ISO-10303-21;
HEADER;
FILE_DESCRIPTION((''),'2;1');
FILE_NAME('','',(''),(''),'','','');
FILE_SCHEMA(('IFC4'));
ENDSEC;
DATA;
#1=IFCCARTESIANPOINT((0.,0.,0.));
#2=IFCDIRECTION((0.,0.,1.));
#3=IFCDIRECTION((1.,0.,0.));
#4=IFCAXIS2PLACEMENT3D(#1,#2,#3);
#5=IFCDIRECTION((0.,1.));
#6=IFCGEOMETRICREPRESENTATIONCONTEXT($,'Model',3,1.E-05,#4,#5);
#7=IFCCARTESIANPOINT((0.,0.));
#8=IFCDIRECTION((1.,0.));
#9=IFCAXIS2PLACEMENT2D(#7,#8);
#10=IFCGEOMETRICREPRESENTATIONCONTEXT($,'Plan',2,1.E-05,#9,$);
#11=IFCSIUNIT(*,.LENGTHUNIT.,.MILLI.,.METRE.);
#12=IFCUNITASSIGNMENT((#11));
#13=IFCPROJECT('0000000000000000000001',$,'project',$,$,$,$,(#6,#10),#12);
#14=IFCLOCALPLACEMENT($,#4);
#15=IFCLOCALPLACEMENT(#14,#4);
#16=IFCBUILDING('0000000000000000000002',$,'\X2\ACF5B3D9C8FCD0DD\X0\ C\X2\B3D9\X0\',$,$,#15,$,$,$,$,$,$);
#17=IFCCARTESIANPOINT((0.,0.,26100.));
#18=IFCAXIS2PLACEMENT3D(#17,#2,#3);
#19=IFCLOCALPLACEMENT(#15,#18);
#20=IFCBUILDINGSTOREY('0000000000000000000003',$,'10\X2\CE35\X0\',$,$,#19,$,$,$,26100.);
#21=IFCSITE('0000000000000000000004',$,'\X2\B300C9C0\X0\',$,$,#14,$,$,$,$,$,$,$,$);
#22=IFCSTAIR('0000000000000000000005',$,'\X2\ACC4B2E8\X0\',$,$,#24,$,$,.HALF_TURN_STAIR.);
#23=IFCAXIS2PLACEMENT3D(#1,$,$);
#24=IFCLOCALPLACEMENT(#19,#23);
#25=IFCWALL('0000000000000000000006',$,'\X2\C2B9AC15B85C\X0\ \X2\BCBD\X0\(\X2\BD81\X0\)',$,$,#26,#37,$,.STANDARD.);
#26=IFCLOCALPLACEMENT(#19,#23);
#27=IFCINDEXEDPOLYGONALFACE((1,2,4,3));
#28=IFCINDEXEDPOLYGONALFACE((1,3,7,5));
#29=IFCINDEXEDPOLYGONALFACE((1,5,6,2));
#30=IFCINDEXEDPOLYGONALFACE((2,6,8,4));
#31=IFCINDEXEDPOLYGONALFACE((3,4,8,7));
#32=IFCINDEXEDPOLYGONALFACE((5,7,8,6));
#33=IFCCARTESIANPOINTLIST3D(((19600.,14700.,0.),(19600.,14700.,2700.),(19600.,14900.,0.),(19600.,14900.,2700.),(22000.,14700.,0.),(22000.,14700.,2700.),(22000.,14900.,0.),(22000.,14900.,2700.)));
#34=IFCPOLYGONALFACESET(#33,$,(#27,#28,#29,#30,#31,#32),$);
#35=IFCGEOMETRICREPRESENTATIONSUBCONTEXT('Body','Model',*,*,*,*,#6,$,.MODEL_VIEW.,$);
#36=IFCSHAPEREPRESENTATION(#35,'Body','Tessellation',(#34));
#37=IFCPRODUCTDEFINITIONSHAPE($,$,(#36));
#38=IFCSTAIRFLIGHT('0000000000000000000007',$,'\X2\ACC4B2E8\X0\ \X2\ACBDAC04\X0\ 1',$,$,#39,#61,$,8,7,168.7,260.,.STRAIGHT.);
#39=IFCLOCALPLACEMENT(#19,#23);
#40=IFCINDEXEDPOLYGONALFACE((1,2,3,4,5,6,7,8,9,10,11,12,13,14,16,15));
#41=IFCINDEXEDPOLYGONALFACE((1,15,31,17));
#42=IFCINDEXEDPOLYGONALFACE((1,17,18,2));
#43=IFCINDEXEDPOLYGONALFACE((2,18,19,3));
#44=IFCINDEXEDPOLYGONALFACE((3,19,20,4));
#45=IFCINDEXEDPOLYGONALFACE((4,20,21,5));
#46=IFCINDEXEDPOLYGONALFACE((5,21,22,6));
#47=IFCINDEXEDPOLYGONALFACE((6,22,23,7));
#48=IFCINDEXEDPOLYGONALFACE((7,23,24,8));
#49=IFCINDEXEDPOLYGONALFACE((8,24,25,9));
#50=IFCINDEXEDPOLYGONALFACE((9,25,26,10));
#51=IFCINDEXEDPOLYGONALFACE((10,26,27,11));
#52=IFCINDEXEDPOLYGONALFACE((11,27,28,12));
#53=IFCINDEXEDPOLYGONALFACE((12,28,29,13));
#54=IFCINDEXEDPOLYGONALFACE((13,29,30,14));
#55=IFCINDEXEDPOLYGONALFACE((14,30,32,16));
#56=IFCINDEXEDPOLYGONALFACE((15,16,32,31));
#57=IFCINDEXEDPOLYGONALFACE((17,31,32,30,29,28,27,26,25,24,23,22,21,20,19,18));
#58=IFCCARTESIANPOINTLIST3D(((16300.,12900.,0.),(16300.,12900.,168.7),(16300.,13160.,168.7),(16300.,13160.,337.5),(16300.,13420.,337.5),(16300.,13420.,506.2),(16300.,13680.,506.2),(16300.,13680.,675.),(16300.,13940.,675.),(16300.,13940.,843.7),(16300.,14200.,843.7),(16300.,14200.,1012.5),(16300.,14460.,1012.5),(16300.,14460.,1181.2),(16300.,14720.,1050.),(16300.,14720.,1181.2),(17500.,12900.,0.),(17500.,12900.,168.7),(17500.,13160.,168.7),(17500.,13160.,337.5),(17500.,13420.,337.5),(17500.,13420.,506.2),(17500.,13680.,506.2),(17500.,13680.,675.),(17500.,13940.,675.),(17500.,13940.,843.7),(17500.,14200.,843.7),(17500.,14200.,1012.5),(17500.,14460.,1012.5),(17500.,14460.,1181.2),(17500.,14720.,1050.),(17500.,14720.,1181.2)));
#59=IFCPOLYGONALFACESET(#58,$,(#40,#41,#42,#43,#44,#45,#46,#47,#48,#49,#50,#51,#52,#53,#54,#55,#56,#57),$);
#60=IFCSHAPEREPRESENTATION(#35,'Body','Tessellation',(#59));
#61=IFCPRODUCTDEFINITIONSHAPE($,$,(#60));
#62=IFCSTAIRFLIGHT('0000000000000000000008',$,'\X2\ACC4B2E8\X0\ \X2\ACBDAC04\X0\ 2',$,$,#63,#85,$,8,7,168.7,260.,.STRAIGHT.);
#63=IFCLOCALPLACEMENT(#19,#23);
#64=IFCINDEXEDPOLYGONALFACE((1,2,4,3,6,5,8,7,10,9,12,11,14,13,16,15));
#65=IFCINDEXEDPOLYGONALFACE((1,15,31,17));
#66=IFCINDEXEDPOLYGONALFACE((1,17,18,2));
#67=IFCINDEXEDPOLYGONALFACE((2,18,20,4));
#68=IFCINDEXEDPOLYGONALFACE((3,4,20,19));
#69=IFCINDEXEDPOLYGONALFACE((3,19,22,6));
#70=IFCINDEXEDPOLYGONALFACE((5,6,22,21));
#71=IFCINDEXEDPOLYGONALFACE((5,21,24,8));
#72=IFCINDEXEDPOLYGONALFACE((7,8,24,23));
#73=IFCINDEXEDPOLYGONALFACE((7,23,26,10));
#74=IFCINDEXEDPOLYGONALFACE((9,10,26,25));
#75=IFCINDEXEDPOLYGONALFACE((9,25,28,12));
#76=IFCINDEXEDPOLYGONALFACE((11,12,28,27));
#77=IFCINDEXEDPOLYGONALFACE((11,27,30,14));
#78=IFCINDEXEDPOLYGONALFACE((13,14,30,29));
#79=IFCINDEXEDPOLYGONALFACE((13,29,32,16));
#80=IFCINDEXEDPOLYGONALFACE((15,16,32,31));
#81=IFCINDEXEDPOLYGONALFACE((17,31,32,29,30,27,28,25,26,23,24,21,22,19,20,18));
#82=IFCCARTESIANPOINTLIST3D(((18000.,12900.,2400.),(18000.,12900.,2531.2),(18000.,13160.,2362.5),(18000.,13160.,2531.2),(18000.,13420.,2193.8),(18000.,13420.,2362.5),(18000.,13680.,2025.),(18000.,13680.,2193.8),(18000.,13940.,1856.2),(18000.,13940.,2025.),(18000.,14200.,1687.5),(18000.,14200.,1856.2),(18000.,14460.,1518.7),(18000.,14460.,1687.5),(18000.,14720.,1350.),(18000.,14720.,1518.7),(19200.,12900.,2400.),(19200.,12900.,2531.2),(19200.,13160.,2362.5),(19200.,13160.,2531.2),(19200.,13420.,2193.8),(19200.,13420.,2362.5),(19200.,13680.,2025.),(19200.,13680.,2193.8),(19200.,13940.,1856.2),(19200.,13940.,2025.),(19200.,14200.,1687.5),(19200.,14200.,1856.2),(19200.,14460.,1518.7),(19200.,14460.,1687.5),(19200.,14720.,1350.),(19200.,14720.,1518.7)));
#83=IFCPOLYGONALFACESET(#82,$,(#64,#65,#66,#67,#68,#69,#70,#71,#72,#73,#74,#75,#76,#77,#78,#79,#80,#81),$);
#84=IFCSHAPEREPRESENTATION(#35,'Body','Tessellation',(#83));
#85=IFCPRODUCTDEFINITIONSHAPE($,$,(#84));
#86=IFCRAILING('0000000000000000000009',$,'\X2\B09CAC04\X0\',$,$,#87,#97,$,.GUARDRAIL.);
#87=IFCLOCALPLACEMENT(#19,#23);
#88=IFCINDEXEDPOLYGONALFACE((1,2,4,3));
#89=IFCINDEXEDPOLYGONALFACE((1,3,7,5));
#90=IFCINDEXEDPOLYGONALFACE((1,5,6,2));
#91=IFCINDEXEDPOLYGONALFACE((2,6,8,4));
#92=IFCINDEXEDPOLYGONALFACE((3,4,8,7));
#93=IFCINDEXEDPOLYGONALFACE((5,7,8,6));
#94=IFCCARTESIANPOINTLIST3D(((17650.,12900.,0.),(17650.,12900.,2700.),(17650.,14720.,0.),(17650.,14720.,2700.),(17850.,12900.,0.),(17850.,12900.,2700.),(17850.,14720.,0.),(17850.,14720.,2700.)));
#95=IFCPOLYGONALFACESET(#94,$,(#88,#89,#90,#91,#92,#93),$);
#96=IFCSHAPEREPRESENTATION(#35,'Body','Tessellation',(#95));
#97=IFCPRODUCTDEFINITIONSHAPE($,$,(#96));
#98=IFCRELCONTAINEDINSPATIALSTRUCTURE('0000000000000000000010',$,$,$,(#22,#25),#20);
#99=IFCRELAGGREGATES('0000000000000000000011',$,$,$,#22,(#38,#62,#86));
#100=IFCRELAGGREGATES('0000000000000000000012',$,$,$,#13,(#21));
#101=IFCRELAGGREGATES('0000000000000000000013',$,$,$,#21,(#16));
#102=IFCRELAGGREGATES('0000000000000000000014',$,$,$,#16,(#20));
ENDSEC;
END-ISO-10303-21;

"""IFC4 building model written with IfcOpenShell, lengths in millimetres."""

from ifc_helpers import new_model, si_unit, direction, frame, origin_with_axes, origin_2d_with_axis, place, context, subcontext, project, spatial, polyline, outline, extrude, element, aggregate, save


model = new_model("IFC4")

# Units and contexts
model_context = context("Model", 3, precision=1e-05, world=origin_with_axes(), true_north=direction((0.0, 1.0)))
plan_context = context("Plan", 2, precision=1e-05, world=origin_2d_with_axis())
body_context = subcontext(model_context, "Body", "Model", "MODEL_VIEW")
ifc_project = project(units=[si_unit("LENGTHUNIT", "METRE", prefix="MILLI")], contexts=[model_context, plan_context])

# Site, building, storey
site_placement = place(None, origin_with_axes())
site = spatial("IfcSite", under=ifc_project, at=site_placement, Name="대지")
building_placement = place(site_placement, origin_with_axes())
building = spatial("IfcBuilding", under=site, at=building_placement, Name="공동주택 C동")
storey_placement = place(building_placement, frame((0.0, 0.0, 26100.0), z_axis=(0.0, 0.0, 1.0), x_axis=(1.0, 0.0, 0.0)))
storey = spatial("IfcBuildingStorey", under=building, at=storey_placement, Name="10층", Elevation=26100.0)

# Stair
stair_placement = place(storey_placement, origin_with_axes())
stair = element("IfcStair", 1, at=stair_placement, inside=storey, Name="계단", PredefinedType="HALF_TURN_STAIR")

# Wall
wall_1_placement = place(storey_placement, origin_with_axes())
element("IfcWall", 2, at=wall_1_placement, inside=storey, Name="승강로 벽(북)", PredefinedType="STANDARD", context=body_context, shape_type="SweptSolid", body=[
    extrude(outline(polyline([(19600.0, 14900.0), (22000.0, 14900.0), (22000.0, 14700.0), (19600.0, 14700.0), (19600.0, 14900.0)])), origin_with_axes(), (0.0, 0.0, 1.0), 2700.0),
])

# Stair flights
stair_flight_1_placement = place(stair_placement, origin_with_axes())
stair_flight_1 = element("IfcStairFlight", 3, at=stair_flight_1_placement, Name="계단 경간 1", NumberOfRisers=8, NumberOfTreads=7, PredefinedType="STRAIGHT", RiserHeight=168.7, TreadLength=260.0, context=body_context, shape_type="SweptSolid", body=[
    extrude(outline(polyline([(0.0, 0.0), (0.0, 168.7), (260.0, 168.7), (260.0, 337.5), (520.0, 337.5), (520.0, 506.2), (780.0, 506.2), (780.0, 675.0), (1040.0, 675.0), (1040.0, 843.7), (1300.0, 843.7), (1300.0, 1012.5), (1560.0, 1012.5), (1560.0, 1181.2), (1820.0, 1181.2), (1820.0, 1350.0), (1820.0, 1050.0), (0.0, 0.0)])), frame((16300.0, 12900.0, 0.0), z_axis=(1.0, 0.0, 0.0), x_axis=(0.0, 1.0, 0.0)), (0.0, 0.0, 1.0), 1200.0),
])
stair_flight_2_placement = place(stair_placement, origin_with_axes())
stair_flight_2 = element("IfcStairFlight", 4, at=stair_flight_2_placement, Name="계단 경간 2", NumberOfRisers=8, NumberOfTreads=7, PredefinedType="STRAIGHT", RiserHeight=168.7, TreadLength=260.0, context=body_context, shape_type="SweptSolid", body=[
    extrude(outline(polyline([(0.0, 0.0), (0.0, 168.7), (260.0, 168.7), (260.0, 337.5), (520.0, 337.5), (520.0, 506.2), (780.0, 506.2), (780.0, 675.0), (1040.0, 675.0), (1040.0, 843.7), (1300.0, 843.7), (1300.0, 1012.5), (1560.0, 1012.5), (1560.0, 1181.2), (1820.0, 1181.2), (1820.0, 1350.0), (1820.0, 1050.0), (0.0, 0.0)])), frame((19200.0, 14720.0, 1350.0), z_axis=(-1.0, 0.0, 0.0), x_axis=(0.0, -1.0, 0.0)), (0.0, 0.0, 1.0), 1200.0),
])

# Railing
railing_placement = place(stair_placement, origin_with_axes())
railing = element("IfcRailing", 5, at=railing_placement, Name="난간", PredefinedType="GUARDRAIL", context=body_context, shape_type="SweptSolid", body=[
    extrude(outline(polyline([(17650.0, 12900.0), (17850.0, 12900.0), (17850.0, 14720.0), (17650.0, 14720.0), (17650.0, 12900.0)])), origin_with_axes(), (0.0, 0.0, 1.0), 2700.0),
])
aggregate(stair, [stair_flight_1, stair_flight_2, railing])

save(model, "model.ifc")
